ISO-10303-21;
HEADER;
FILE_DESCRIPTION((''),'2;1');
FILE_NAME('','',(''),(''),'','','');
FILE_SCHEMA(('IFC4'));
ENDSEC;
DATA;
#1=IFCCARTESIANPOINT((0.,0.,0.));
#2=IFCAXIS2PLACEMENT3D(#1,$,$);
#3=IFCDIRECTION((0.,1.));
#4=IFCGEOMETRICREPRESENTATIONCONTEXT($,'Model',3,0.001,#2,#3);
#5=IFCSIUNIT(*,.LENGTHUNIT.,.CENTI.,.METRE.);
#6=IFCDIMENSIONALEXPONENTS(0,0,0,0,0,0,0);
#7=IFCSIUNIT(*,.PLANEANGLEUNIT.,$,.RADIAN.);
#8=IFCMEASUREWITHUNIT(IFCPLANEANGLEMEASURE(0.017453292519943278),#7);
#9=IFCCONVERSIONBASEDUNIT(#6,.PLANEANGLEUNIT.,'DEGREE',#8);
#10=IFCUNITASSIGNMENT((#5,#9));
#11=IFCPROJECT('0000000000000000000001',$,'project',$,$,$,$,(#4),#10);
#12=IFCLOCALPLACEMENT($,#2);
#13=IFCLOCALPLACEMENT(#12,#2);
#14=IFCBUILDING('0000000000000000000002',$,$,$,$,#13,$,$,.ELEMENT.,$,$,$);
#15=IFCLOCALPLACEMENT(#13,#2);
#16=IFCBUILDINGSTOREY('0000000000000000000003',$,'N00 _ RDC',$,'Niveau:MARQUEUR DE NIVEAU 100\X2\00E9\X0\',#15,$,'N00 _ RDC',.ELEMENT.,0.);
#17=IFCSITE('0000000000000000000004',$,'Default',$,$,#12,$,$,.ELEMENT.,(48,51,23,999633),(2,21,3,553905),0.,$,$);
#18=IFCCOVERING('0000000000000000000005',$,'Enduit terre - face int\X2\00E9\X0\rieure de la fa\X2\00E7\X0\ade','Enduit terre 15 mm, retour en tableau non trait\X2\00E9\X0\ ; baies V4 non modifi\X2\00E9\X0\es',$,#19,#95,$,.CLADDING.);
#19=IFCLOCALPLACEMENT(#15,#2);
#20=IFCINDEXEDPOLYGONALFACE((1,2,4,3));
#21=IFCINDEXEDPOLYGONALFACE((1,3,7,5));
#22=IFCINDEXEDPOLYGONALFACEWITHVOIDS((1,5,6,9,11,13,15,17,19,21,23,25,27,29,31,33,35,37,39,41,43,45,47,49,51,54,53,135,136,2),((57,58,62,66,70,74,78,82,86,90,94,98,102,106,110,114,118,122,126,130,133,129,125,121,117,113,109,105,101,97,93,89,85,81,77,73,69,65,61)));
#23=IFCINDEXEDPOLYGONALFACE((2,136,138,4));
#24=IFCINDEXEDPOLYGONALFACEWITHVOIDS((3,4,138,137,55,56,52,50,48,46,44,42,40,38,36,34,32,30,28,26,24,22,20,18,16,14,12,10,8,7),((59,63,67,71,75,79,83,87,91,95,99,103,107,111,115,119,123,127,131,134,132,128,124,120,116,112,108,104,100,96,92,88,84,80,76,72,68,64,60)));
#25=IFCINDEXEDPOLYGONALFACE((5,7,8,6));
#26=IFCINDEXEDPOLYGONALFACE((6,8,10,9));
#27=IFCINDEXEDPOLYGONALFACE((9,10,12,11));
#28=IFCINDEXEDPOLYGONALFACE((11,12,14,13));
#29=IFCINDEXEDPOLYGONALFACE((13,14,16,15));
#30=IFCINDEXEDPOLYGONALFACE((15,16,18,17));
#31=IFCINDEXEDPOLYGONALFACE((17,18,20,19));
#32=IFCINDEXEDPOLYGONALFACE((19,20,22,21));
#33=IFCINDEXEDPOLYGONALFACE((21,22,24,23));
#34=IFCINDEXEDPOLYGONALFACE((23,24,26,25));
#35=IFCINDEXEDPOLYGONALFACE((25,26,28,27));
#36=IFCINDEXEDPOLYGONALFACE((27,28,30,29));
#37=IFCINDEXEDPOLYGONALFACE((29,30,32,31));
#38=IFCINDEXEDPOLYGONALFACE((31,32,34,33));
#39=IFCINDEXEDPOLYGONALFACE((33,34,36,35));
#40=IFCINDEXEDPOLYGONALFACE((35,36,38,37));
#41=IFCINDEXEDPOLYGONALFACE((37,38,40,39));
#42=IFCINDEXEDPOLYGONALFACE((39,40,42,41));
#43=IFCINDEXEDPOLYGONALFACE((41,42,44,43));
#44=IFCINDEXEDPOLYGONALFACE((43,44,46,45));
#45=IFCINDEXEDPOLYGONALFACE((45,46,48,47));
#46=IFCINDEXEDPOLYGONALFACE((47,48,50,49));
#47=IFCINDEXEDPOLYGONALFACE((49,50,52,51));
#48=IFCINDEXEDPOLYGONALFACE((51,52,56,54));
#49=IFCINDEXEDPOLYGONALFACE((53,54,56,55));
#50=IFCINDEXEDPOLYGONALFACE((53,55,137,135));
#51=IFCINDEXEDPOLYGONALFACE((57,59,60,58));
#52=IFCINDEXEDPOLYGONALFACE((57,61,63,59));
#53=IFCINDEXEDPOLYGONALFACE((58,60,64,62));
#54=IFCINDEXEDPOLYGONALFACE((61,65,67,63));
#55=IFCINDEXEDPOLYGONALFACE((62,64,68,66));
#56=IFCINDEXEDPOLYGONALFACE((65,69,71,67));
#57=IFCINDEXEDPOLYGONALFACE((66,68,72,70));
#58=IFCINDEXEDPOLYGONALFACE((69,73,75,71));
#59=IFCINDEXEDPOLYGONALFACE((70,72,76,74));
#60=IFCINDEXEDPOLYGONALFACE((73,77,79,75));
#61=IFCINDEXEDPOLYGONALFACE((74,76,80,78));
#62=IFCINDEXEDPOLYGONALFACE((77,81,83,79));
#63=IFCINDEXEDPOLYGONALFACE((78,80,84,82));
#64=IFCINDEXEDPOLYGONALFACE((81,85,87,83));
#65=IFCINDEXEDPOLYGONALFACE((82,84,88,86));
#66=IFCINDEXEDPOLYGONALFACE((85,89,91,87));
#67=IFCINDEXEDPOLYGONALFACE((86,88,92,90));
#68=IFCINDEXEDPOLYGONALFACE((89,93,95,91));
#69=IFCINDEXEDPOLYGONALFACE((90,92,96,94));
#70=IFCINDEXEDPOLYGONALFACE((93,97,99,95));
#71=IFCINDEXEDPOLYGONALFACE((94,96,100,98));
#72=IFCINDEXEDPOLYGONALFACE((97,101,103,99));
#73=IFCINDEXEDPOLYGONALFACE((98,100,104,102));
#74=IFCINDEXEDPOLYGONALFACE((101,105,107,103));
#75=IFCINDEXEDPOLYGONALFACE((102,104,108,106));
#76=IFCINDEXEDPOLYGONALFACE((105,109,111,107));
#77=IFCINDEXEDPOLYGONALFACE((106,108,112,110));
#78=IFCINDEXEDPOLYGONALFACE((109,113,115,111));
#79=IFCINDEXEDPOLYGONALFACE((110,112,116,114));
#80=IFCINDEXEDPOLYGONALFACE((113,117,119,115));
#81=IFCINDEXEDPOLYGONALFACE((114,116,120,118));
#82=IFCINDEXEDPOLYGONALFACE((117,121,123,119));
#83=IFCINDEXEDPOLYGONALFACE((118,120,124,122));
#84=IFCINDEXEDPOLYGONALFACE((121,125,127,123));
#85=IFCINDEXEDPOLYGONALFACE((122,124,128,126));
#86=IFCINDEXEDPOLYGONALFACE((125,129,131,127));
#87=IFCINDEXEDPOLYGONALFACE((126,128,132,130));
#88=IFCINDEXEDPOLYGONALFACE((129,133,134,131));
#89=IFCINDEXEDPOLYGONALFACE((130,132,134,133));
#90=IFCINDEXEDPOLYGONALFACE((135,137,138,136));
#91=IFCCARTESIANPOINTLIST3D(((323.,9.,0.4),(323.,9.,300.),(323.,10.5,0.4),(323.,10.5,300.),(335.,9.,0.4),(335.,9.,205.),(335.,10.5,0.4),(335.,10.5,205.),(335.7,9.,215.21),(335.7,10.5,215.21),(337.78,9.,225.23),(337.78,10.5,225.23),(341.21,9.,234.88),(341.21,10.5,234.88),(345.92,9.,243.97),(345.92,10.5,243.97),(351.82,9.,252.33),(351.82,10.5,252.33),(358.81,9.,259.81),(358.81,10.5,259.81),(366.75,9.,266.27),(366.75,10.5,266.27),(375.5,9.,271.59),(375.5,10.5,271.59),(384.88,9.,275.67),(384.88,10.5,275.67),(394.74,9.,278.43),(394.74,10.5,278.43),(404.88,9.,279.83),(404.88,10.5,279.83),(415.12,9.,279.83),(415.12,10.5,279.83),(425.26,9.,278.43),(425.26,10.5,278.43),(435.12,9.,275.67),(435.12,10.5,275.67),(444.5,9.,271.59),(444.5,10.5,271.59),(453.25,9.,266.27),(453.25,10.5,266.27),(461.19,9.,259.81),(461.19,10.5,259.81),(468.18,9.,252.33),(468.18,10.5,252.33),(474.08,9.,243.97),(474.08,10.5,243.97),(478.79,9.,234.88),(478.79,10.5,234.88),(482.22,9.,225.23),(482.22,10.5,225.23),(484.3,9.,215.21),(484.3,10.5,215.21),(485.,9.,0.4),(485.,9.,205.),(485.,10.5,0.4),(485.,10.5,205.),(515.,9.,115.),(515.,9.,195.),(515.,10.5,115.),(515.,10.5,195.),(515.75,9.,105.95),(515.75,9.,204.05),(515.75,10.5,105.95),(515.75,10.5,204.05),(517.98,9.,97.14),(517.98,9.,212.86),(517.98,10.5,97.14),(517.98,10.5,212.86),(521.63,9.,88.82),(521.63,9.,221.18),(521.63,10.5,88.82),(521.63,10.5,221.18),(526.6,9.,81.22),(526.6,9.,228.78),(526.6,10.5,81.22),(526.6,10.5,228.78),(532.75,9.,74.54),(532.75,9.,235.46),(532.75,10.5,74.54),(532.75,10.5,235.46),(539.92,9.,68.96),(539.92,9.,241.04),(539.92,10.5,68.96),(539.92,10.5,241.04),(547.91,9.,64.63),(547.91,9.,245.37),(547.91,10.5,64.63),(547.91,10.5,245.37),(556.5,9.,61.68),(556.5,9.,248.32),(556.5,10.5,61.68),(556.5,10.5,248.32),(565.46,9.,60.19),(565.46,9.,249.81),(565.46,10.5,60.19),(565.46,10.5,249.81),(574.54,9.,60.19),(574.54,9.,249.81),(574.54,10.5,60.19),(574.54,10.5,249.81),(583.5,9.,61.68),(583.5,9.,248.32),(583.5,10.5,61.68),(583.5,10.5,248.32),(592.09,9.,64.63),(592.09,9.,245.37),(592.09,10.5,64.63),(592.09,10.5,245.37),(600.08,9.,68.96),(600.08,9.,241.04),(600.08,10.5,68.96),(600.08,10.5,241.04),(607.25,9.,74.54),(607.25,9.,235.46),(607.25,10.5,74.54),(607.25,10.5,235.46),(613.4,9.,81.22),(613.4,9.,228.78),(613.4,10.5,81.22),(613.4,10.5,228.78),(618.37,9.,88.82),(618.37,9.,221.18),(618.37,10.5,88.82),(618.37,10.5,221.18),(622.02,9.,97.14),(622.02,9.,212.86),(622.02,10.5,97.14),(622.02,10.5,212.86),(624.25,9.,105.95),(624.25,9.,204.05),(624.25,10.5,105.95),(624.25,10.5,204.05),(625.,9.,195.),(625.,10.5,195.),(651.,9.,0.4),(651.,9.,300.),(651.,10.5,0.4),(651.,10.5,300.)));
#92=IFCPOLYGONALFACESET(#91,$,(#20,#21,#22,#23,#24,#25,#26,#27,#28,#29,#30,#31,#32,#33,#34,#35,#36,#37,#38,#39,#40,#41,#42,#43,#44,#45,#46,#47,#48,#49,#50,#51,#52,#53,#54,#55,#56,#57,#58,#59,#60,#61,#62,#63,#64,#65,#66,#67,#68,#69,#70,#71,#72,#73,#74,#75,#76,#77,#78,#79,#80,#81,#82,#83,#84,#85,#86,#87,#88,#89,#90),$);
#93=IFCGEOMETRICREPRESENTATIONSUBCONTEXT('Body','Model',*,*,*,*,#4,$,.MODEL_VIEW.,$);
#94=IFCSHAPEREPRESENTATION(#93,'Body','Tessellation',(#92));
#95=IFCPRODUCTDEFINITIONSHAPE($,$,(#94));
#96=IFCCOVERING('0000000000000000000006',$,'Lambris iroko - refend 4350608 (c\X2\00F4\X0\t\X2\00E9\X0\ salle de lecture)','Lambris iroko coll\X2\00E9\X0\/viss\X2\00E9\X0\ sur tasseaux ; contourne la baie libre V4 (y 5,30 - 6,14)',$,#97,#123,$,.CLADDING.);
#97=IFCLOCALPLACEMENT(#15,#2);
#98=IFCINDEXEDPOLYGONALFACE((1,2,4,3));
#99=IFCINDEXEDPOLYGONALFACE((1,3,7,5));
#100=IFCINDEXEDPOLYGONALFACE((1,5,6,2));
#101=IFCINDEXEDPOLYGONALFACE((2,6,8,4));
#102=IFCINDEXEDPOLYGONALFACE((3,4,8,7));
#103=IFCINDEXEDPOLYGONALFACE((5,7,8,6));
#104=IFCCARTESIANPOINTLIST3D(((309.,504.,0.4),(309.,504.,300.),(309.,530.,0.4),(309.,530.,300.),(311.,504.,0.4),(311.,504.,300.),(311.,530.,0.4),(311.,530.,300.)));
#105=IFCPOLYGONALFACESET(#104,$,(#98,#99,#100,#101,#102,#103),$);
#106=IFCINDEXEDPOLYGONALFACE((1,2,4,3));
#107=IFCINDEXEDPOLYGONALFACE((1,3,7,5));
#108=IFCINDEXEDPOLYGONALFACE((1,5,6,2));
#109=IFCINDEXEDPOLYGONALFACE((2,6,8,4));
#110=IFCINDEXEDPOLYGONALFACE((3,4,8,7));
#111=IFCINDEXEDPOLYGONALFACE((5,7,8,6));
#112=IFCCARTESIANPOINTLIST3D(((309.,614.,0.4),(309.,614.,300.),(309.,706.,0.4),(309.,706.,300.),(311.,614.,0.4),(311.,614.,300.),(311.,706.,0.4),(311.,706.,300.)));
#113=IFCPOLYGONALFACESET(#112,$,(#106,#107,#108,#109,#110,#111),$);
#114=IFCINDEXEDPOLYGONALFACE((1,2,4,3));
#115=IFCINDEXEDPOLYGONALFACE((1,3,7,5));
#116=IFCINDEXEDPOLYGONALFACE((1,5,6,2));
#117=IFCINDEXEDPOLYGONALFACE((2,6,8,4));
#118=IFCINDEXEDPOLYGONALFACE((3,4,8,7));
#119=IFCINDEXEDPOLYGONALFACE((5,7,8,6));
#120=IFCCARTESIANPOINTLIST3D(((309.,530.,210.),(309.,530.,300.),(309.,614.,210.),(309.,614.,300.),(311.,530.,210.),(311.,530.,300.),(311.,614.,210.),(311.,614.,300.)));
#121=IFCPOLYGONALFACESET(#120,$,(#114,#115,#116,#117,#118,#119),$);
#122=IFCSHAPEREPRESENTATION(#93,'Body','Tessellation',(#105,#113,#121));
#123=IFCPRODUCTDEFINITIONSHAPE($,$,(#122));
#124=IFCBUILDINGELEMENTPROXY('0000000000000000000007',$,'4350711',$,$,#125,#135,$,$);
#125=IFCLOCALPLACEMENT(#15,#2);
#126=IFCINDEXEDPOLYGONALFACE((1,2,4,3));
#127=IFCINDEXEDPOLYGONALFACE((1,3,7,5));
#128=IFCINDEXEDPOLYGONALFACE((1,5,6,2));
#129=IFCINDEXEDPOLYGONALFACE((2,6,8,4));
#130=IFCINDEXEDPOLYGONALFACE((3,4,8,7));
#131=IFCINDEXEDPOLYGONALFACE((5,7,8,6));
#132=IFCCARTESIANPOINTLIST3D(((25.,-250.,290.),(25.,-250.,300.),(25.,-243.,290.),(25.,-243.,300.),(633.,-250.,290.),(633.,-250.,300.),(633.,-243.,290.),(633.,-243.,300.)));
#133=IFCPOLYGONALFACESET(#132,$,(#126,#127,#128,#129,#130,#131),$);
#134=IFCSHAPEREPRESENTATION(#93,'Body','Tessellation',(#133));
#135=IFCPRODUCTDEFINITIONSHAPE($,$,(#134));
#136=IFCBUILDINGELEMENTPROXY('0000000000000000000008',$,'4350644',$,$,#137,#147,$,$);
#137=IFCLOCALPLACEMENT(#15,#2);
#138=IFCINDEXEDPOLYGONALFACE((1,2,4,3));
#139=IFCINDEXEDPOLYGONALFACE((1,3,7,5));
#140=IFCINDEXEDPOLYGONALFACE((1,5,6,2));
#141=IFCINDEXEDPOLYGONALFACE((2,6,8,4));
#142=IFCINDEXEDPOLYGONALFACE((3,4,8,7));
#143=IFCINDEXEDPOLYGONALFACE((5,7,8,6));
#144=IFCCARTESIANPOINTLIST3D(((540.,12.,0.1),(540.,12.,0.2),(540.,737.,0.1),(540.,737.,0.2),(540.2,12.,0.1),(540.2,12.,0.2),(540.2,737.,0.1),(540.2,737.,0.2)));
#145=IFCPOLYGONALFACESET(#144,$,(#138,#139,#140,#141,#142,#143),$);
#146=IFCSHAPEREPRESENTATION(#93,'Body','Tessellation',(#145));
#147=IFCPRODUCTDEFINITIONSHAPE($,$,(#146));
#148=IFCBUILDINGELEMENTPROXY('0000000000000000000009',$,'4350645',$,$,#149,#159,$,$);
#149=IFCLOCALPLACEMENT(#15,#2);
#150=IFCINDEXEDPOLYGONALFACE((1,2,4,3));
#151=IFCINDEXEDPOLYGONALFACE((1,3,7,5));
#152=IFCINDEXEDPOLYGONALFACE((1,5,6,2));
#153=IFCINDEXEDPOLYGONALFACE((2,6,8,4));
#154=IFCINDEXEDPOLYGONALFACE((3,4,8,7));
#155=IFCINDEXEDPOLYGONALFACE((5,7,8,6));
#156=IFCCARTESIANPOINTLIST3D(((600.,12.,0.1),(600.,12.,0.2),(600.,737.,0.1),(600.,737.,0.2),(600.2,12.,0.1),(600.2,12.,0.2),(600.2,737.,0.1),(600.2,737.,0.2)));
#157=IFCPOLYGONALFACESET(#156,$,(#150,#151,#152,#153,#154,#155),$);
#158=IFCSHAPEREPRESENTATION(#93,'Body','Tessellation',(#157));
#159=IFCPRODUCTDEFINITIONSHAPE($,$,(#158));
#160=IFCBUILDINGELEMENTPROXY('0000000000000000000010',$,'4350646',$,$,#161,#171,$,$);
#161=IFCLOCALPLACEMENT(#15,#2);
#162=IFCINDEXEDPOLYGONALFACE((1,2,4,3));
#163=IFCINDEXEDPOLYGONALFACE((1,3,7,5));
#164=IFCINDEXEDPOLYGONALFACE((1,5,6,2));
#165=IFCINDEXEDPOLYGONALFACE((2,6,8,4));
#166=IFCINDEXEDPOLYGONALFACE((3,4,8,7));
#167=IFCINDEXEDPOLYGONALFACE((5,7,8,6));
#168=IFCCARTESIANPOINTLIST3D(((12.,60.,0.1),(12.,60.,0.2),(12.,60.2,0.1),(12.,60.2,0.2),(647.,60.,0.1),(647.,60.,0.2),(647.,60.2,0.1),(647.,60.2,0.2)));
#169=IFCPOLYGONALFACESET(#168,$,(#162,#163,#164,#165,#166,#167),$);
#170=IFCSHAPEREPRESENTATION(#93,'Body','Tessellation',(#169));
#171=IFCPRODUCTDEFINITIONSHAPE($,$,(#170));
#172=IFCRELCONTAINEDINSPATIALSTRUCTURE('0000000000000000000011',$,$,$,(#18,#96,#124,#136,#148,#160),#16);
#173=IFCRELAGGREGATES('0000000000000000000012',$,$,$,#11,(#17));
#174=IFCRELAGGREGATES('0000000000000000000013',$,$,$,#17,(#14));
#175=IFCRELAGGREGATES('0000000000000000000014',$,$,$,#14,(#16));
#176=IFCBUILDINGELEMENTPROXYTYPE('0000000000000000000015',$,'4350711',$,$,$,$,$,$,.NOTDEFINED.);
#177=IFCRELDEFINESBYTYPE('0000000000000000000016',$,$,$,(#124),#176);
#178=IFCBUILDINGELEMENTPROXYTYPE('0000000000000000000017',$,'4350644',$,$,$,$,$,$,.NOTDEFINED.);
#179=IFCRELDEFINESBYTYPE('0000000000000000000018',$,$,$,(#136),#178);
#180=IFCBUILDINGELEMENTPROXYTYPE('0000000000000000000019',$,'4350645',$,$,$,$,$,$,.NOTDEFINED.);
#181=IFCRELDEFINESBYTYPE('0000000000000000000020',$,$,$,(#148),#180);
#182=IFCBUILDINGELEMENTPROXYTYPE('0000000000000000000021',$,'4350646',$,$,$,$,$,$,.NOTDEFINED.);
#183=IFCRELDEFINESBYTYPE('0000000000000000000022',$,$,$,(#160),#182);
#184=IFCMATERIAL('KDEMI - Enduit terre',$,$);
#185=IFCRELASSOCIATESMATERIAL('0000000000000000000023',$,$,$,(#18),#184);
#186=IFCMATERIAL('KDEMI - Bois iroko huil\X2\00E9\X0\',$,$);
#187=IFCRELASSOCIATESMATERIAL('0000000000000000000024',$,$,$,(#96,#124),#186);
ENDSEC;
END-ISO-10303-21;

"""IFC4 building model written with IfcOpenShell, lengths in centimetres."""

from ifc_helpers import new_model, entity, si_unit, converted_unit, direction, frame, frame_2d, origin, origin_with_axes, origin_2d_with_axis, place, context, subcontext, project, spatial, polyline, rectangle, outline, extrude, material, type_object, element, save


model = new_model("IFC4")

# Units and contexts
model_context = context("Model", 3, precision=0.001, world=origin(), true_north=direction((0.0, 1.0)))
body_context = subcontext(model_context, "Body", "Model", "MODEL_VIEW")
ifc_project = project(units=[si_unit("LENGTHUNIT", "METRE", prefix="CENTI"), converted_unit("PLANEANGLEUNIT", "DEGREE", entity("IfcPlaneAngleMeasure", 0.017453292519943278), si_unit("PLANEANGLEUNIT", "RADIAN"), dimensions=[0, 0, 0, 0, 0, 0, 0])], contexts=[model_context])

# Site, building, storey
site_placement = place(None, origin())
site = spatial("IfcSite", under=ifc_project, at=site_placement, Name="Default", CompositionType="ELEMENT", RefLatitude=(48, 51, 23, 999633), RefLongitude=(2, 21, 3, 553905), RefElevation=0.0)
building_placement = place(site_placement, origin())
building = spatial("IfcBuilding", under=site, at=building_placement, CompositionType="ELEMENT")
storey_placement = place(building_placement, origin())
storey = spatial("IfcBuildingStorey", under=building, at=storey_placement, Name="N00 _ RDC", ObjectType="Niveau:MARQUEUR DE NIVEAU 100é", LongName="N00 _ RDC", CompositionType="ELEMENT", Elevation=0.0)

# Shared definitions
ifc_material_1 = material(Name="KDEMI - Bois iroko huilé")

# Coverings
ifc_material_2 = material(Name="KDEMI - Enduit terre")
covering_1_placement = place(storey_placement, origin_with_axes())
element("IfcCovering", 1, at=covering_1_placement, inside=storey, material=ifc_material_2, Name="Enduit terre - face intérieure de la façade", Description="Enduit terre 15 mm, retour en tableau non traité ; baies V4 non modifiées", PredefinedType="CLADDING", context=body_context, shape_type="SweptSolid", body=[
    extrude(outline(polyline([(323.0, 300.0), (651.0, 300.0), (651.0, 0.4), (485.0, 0.4), (485.0, 205.0), (484.3, 215.21), (482.22, 225.23), (478.79, 234.88), (474.08, 243.97), (468.18, 252.33), (461.19, 259.81), (453.25, 266.27), (444.5, 271.59), (435.12, 275.67), (425.26, 278.43), (415.12, 279.83), (404.88, 279.83), (394.74, 278.43), (384.88, 275.67), (375.5, 271.59), (366.75, 266.27), (358.81, 259.81), (351.82, 252.33), (345.92, 243.97), (341.21, 234.88), (337.78, 225.23), (335.7, 215.21), (335.0, 205.0), (335.0, 0.4), (323.0, 0.4), (323.0, 300.0)]), holes=[polyline([(624.25, 204.05), (622.02, 212.86), (618.37, 221.18), (613.4, 228.78), (607.25, 235.46), (600.08, 241.04), (592.09, 245.37), (583.5, 248.32), (574.54, 249.81), (565.46, 249.81), (556.5, 248.32), (547.91, 245.37), (539.92, 241.04), (532.75, 235.46), (526.6, 228.78), (521.63, 221.18), (517.98, 212.86), (515.75, 204.05), (515.0, 195.0), (515.0, 115.0), (515.75, 105.95), (517.98, 97.14), (521.63, 88.82), (526.6, 81.22), (532.75, 74.54), (539.92, 68.96), (547.91, 64.63), (556.5, 61.68), (565.46, 60.19), (574.54, 60.19), (583.5, 61.68), (592.09, 64.63), (600.08, 68.96), (607.25, 74.54), (613.4, 81.22), (618.37, 88.82), (622.02, 97.14), (624.25, 105.95), (625.0, 195.0), (624.25, 204.05)])]), frame((0.0, 10.5, 0.0), z_axis=(0.0, -1.0, 0.0), x_axis=(1.0, 0.0, 0.0)), (0.0, 0.0, 1.0), 1.5),
])
covering_2_placement = place(storey_placement, origin_with_axes())
element("IfcCovering", 2, at=covering_2_placement, inside=storey, material=ifc_material_1, Name="Lambris iroko - refend 4350608 (côté salle de lecture)", Description="Lambris iroko collé/vissé sur tasseaux ; contourne la baie libre V4 (y 5,30 - 6,14)", PredefinedType="CLADDING", context=body_context, shape_type="SweptSolid", body=[
    extrude(rectangle(XDim=2.0, YDim=26.0, at=frame_2d((310.0, 517.0))), frame((0.0, 0.0, 0.4)), (0.0, 0.0, 1.0), 299.6),
    extrude(rectangle(XDim=2.0, YDim=92.0, at=frame_2d((310.0, 660.0))), frame((0.0, 0.0, 0.4)), (0.0, 0.0, 1.0), 299.6),
    extrude(rectangle(XDim=2.0, YDim=84.0, at=frame_2d((310.0, 572.0))), frame((0.0, 0.0, 210.0)), (0.0, 0.0, 1.0), 90.0),
])

# Building element proxies
building_element_proxy_type_1 = type_object("IfcBuildingElementProxyType", Name="4350711", PredefinedType="NOTDEFINED")
proxy_1_placement = place(storey_placement, frame((0.0, 0.0, 25.0), z_axis=(0.0, 0.0, 1.0), x_axis=(1.0, 0.0, 0.0)))
element("IfcBuildingElementProxy", 3, at=proxy_1_placement, inside=storey, type_object=building_element_proxy_type_1, material=ifc_material_1, Name="4350711", context=body_context, shape_type="SweptSolid", body=[
    extrude(rectangle(XDim=608.0, YDim=7.0, at=frame_2d((0.0, 0.0), x_axis=(1.0, 0.0))), frame((329.0, -246.5, 265.0)), (0.0, 0.0, 1.0), 10.0),
])
building_element_proxy_type_2 = type_object("IfcBuildingElementProxyType", Name="4350644", PredefinedType="NOTDEFINED")
proxy_2_placement = place(storey_placement, origin())
element("IfcBuildingElementProxy", 4, at=proxy_2_placement, inside=storey, type_object=building_element_proxy_type_2, Name="4350644", context=body_context, shape_type="SweptSolid", body=[
    extrude(rectangle(XDim=0.2, YDim=725.0, at=origin_2d_with_axis()), frame((540.1, 374.5, 0.1)), (0.0, 0.0, 1.0), 0.1),
])
building_element_proxy_type_3 = type_object("IfcBuildingElementProxyType", Name="4350645", PredefinedType="NOTDEFINED")
proxy_3_placement = place(storey_placement, origin())
element("IfcBuildingElementProxy", 5, at=proxy_3_placement, inside=storey, type_object=building_element_proxy_type_3, Name="4350645", context=body_context, shape_type="SweptSolid", body=[
    extrude(rectangle(XDim=0.2, YDim=725.0, at=origin_2d_with_axis()), frame((600.1, 374.5, 0.1)), (0.0, 0.0, 1.0), 0.1),
])
building_element_proxy_type_4 = type_object("IfcBuildingElementProxyType", Name="4350646", PredefinedType="NOTDEFINED")
proxy_4_placement = place(storey_placement, origin())
element("IfcBuildingElementProxy", 6, at=proxy_4_placement, inside=storey, type_object=building_element_proxy_type_4, Name="4350646", context=body_context, shape_type="SweptSolid", body=[
    extrude(rectangle(XDim=635.0, YDim=0.2, at=frame_2d((0.0, 0.0), x_axis=(1.0, 0.0))), frame((329.5, 60.1, 0.1)), (0.0, 0.0, 1.0), 0.1),
])

save(model, "model.ifc")
